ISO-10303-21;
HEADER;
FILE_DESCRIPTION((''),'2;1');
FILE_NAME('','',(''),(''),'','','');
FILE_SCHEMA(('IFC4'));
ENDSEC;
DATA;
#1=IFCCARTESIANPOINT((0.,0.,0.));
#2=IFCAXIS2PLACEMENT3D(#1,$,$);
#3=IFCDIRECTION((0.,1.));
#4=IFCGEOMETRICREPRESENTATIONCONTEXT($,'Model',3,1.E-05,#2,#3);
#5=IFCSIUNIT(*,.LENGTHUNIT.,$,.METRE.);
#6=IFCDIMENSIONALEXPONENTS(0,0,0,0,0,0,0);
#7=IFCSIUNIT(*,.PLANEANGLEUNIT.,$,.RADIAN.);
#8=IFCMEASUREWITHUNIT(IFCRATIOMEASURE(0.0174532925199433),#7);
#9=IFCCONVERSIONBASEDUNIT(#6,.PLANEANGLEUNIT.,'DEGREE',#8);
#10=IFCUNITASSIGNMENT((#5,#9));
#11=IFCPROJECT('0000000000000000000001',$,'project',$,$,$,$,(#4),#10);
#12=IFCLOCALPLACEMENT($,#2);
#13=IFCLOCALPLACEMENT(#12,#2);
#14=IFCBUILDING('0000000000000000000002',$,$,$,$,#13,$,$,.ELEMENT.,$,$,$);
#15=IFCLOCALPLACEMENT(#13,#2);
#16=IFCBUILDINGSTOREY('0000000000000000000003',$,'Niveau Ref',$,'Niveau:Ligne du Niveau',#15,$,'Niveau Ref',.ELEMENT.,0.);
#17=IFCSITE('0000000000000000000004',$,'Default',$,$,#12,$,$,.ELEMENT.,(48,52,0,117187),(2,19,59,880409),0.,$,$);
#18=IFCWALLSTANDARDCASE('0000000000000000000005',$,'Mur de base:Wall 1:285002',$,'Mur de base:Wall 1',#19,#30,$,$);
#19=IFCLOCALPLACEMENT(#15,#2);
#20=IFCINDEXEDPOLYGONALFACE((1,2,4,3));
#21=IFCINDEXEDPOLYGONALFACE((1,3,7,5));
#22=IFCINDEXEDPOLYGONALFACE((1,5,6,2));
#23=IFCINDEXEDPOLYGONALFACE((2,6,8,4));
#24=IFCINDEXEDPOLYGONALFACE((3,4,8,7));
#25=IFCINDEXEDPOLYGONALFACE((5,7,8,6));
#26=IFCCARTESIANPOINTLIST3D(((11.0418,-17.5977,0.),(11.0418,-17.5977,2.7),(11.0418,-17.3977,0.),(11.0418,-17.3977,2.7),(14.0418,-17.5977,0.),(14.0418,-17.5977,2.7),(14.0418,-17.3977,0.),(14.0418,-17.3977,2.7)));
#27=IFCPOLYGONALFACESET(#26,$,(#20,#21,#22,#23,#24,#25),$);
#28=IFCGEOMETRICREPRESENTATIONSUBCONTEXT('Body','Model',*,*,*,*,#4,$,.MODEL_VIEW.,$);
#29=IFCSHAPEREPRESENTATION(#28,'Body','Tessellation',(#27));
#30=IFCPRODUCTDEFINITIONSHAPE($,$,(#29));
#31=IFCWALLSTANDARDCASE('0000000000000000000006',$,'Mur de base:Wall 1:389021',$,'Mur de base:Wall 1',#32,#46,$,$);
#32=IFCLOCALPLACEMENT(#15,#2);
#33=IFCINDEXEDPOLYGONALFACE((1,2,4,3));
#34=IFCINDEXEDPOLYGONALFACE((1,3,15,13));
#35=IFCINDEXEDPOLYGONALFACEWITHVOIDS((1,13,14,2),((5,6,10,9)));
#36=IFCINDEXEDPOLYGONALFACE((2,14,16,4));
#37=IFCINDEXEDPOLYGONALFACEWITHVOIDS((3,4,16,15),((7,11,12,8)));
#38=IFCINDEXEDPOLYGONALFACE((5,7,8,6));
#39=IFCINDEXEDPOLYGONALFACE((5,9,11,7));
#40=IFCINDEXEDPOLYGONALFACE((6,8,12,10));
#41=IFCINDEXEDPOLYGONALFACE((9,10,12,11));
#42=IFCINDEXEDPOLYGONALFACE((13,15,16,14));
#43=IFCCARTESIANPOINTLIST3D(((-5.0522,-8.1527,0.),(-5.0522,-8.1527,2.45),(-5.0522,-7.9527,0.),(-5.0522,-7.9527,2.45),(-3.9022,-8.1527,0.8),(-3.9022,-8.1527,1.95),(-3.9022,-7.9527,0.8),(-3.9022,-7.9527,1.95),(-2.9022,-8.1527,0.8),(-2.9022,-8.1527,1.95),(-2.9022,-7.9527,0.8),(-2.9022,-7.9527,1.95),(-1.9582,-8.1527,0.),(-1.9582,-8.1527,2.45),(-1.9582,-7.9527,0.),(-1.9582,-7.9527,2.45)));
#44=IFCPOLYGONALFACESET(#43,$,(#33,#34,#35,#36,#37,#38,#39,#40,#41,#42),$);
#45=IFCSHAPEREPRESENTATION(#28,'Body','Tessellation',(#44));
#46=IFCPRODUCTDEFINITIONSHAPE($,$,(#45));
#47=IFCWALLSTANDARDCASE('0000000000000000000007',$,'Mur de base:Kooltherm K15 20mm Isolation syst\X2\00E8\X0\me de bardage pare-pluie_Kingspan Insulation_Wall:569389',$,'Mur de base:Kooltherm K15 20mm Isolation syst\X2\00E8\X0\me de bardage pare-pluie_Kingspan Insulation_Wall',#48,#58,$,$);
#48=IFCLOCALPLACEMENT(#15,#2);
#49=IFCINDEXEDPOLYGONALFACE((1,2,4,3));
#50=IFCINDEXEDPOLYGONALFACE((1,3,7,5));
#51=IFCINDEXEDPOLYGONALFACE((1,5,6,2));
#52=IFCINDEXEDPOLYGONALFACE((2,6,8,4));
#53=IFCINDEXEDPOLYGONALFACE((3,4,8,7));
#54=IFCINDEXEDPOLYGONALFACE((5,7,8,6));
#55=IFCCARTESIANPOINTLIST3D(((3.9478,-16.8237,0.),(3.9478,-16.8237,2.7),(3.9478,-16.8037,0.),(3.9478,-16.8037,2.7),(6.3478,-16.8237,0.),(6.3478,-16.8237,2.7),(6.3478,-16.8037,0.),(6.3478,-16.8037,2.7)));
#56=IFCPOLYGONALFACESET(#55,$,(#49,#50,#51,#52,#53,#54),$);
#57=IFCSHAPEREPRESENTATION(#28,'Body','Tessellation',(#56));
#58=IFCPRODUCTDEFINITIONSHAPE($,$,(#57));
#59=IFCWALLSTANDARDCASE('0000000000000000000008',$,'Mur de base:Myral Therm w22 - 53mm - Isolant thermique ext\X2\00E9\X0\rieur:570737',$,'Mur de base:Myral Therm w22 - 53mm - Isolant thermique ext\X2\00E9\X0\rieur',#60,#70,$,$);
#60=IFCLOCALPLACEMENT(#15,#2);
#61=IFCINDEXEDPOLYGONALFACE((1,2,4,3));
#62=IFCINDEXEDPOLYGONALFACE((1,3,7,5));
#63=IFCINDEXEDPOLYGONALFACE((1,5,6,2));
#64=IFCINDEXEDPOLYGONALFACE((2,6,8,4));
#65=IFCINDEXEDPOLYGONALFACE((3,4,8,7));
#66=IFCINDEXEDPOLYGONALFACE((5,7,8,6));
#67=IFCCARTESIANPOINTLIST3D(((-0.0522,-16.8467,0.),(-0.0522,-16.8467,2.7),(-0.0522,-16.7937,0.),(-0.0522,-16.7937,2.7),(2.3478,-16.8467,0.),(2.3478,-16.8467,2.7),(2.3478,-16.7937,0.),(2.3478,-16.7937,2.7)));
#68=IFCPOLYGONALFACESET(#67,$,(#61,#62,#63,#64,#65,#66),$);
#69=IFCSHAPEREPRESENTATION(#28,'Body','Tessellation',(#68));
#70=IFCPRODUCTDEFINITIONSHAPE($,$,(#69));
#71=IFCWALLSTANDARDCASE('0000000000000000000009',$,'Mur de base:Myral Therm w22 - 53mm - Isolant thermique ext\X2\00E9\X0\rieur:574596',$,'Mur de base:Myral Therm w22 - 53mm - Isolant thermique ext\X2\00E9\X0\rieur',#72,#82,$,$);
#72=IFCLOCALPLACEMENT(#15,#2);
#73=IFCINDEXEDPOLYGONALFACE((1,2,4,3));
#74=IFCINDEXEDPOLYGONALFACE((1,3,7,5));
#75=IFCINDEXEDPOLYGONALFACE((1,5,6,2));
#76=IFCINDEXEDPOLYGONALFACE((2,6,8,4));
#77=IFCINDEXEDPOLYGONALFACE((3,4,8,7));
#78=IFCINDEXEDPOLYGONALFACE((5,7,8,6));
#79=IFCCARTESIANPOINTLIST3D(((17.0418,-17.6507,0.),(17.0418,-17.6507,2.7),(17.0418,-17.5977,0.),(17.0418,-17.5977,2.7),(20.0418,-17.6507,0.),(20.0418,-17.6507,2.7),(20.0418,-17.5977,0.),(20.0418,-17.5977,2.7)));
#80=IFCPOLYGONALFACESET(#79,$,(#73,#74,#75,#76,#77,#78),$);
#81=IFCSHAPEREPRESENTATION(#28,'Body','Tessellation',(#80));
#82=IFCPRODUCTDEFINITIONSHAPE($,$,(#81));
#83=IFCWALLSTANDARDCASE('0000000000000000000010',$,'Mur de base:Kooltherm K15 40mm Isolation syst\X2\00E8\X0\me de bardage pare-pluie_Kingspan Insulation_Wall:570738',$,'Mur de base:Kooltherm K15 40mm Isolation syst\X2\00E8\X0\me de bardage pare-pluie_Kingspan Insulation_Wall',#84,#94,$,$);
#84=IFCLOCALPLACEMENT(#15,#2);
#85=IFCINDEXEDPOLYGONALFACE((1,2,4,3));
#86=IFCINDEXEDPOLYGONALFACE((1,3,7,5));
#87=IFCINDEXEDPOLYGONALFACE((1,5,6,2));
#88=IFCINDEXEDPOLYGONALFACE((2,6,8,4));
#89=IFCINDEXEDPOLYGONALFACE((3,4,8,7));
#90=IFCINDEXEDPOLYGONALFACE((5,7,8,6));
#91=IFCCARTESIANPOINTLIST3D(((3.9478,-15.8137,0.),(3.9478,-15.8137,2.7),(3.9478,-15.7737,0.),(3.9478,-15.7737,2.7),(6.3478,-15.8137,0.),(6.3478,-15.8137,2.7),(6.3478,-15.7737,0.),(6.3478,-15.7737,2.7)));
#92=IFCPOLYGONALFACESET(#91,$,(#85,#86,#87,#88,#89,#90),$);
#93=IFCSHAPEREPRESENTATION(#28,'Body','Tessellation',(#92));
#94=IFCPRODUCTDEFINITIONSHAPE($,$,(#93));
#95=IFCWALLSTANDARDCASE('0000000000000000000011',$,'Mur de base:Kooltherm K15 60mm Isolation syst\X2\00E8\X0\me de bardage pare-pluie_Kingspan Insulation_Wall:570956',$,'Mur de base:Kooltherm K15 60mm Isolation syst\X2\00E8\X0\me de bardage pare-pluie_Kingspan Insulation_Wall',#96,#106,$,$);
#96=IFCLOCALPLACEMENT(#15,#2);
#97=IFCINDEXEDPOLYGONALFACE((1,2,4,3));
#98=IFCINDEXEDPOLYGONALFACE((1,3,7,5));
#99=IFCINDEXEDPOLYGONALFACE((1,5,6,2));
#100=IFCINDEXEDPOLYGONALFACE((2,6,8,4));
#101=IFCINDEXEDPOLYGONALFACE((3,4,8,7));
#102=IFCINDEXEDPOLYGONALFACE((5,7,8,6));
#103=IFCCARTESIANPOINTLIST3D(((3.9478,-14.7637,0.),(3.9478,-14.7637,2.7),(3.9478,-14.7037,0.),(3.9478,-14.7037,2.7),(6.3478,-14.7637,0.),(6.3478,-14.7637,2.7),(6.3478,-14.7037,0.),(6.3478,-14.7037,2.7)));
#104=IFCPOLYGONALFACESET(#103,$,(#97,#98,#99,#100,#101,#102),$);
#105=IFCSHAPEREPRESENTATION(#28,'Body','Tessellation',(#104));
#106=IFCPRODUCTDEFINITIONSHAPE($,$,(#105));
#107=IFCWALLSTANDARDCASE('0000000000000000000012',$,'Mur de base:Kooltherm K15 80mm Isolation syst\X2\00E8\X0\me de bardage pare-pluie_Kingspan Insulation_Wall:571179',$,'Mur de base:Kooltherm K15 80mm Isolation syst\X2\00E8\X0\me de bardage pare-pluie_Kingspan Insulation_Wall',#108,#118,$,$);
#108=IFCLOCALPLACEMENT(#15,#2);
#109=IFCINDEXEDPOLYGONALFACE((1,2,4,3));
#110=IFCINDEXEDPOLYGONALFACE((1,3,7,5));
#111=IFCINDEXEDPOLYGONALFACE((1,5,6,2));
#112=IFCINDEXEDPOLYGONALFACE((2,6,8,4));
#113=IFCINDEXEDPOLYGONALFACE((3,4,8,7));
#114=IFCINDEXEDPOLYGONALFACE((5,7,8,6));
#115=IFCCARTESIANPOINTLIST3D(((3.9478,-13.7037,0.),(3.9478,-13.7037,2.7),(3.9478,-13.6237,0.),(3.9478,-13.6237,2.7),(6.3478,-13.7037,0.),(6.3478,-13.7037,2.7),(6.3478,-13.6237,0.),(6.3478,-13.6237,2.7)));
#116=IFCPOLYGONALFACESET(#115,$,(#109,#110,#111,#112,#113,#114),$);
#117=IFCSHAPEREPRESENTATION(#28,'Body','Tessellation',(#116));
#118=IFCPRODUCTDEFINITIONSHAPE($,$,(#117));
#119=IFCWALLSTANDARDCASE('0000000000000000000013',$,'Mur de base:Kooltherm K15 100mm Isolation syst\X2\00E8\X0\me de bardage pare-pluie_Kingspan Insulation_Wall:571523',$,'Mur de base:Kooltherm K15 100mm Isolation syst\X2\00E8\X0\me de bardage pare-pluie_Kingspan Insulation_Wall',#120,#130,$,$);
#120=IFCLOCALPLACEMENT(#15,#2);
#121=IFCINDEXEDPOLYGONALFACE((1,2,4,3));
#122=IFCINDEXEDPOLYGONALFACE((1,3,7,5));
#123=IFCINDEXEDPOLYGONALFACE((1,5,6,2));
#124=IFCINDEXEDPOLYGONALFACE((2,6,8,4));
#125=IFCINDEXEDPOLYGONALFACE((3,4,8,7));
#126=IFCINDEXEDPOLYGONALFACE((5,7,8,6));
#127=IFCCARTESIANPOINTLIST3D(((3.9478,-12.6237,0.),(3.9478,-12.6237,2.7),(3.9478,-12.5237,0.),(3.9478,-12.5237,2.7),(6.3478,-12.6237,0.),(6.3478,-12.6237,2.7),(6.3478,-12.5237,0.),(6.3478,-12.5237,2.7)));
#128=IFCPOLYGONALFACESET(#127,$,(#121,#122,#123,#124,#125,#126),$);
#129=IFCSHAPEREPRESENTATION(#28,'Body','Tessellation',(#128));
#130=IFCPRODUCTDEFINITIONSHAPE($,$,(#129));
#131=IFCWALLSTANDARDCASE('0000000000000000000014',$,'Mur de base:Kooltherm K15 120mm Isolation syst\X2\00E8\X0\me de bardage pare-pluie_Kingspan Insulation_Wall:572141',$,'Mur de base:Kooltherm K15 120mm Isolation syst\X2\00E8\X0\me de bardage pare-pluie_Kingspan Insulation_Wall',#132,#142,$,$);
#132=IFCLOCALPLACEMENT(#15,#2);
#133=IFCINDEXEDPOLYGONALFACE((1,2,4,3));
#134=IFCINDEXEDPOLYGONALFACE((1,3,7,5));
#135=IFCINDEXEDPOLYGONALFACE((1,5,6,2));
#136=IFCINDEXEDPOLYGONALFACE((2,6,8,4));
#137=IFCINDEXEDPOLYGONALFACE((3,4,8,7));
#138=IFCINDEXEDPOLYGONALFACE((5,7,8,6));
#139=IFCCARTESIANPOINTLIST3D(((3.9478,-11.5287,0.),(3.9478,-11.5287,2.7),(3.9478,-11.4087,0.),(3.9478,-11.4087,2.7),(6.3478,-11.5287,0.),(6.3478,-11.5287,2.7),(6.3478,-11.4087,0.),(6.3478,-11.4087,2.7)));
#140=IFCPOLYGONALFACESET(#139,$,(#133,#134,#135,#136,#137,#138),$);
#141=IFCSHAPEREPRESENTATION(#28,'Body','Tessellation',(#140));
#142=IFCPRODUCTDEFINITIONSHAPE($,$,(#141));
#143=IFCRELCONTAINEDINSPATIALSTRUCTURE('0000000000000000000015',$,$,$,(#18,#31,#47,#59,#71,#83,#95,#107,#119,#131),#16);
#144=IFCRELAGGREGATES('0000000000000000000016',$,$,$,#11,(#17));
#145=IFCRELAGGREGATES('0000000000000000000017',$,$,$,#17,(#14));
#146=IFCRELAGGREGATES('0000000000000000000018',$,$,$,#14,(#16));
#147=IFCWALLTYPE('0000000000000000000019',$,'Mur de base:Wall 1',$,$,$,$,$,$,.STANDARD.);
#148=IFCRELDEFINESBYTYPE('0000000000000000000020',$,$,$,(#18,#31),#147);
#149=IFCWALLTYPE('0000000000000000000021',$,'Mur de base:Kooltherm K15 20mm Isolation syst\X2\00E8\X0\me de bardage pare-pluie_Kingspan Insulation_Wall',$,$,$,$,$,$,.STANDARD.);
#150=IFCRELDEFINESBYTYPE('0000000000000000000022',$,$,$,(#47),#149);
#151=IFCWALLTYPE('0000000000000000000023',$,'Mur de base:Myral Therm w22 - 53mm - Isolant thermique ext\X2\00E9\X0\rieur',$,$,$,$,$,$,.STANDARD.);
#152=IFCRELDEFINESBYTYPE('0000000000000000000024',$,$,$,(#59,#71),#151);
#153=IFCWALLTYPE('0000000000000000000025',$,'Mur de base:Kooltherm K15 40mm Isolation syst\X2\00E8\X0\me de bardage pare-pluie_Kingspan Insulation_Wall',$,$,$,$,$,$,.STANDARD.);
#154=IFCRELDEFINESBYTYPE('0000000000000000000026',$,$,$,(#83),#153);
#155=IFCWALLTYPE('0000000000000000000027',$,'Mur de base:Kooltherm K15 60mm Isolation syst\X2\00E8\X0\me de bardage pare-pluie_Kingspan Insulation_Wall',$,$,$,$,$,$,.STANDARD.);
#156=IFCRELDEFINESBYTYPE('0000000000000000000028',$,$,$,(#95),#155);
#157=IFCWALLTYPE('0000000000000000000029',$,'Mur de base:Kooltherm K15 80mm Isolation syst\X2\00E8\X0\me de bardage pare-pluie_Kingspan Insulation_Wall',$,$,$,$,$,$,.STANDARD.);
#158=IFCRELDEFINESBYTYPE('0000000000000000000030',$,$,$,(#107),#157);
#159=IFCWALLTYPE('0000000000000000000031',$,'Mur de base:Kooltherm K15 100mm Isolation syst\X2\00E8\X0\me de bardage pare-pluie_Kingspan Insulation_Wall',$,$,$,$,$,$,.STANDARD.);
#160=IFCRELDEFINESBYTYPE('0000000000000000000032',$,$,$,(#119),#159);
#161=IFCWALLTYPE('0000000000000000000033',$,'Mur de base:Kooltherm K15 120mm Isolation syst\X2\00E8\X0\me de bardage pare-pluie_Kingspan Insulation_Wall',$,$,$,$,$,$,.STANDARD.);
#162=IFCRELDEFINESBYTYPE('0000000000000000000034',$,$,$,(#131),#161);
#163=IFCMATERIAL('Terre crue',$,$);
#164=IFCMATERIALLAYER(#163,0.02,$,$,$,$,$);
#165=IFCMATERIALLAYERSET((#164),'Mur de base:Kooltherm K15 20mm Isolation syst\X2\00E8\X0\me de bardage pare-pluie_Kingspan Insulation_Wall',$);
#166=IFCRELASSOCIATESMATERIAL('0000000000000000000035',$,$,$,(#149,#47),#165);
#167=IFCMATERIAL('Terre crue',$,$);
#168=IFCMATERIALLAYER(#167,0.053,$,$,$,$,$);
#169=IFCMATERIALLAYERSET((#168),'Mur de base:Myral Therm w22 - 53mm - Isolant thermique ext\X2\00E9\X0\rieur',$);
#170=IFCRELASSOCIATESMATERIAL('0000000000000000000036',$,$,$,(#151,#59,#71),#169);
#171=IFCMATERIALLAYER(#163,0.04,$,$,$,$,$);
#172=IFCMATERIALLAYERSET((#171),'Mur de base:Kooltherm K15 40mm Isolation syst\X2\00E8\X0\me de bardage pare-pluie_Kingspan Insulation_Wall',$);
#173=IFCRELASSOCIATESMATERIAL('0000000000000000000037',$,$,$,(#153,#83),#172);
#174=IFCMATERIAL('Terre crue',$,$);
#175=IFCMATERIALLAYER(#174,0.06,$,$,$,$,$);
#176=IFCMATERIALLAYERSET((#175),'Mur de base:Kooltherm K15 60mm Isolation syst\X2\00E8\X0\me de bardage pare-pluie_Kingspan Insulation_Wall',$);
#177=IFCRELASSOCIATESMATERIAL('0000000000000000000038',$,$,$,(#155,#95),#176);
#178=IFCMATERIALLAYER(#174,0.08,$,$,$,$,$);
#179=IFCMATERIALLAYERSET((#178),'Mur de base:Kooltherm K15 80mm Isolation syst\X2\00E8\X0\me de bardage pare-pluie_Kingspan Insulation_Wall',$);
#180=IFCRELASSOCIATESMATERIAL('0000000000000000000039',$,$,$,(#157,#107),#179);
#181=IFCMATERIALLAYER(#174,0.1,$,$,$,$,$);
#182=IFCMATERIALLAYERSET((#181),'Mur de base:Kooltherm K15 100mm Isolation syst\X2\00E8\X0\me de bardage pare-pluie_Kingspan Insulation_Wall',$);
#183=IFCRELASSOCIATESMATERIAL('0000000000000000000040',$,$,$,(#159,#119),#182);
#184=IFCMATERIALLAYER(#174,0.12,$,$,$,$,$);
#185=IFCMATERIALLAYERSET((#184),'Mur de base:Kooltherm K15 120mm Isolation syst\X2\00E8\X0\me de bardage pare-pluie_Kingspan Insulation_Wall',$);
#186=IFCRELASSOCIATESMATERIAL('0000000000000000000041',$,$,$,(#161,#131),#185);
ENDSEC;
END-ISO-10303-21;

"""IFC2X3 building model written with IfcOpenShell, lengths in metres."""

from ifc_helpers import new_model, entity, si_unit, converted_unit, direction, frame, frame_2d, origin, place, context, subcontext, project, spatial, rectangle, extrude, material, layer, layer_set, layer_usage, type_object, element, save


model = new_model("IFC2X3")

# Units and contexts
model_context = context("Model", 3, precision=1e-05, world=origin(), true_north=direction((0.0, 1.0)))
body_context = subcontext(model_context, "Body", "Model", "MODEL_VIEW")
ifc_project = project(units=[si_unit("LENGTHUNIT", "METRE"), converted_unit("PLANEANGLEUNIT", "DEGREE", entity("IfcRatioMeasure", 0.0174532925199433), si_unit("PLANEANGLEUNIT", "RADIAN"), dimensions=[0, 0, 0, 0, 0, 0, 0])], contexts=[model_context])

# Site, building, storey
site_placement = place(None, origin())
site = spatial("IfcSite", under=ifc_project, at=site_placement, Name="Default", CompositionType="ELEMENT", RefLatitude=(48, 52, 0, 117187), RefLongitude=(2, 19, 59, 880409), RefElevation=0.0)
building_placement = place(site_placement, origin())
building = spatial("IfcBuilding", under=site, at=building_placement, CompositionType="ELEMENT")
storey_placement = place(building_placement, origin())
storey = spatial("IfcBuildingStorey", under=building, at=storey_placement, Name="Niveau Ref", ObjectType="Niveau:Ligne du Niveau", LongName="Niveau Ref", CompositionType="ELEMENT", Elevation=0.0)

# Wall
wall_type_1 = type_object("IfcWallType", Name="Mur de base:Wall 1", PredefinedType="STANDARD")
for number, where, name in (
    (1, (11.0418, -17.4977, 0.0), "Mur de base:Wall 1:285002"),
):
    element("IfcWallStandardCase", number, at=place(storey_placement, frame(where)), inside=storey, type_object=wall_type_1, Name=name, ObjectType="Mur de base:Wall 1", context=body_context, shape_type="SweptSolid", body=[
        extrude(rectangle(XDim=3.0, YDim=0.2, at=frame_2d((1.5, 0.0), x_axis=(-1.0, 0.0))), origin(), (0.0, 0.0, 1.0), 2.7),
    ])

# Wall, opening
wall_1_placement = place(storey_placement, frame((-1.9582, -8.0527, 0.0), z_axis=(0.0, 0.0, 1.0), x_axis=(-1.0, 0.0, 0.0)))
wall_1 = element("IfcWallStandardCase", 2, at=wall_1_placement, inside=storey, type_object=wall_type_1, Name="Mur de base:Wall 1:389021", ObjectType="Mur de base:Wall 1", context=body_context, shape_type="SweptSolid", body=[
    extrude(rectangle(XDim=3.094, YDim=0.2, at=frame_2d((1.547, 0.0), x_axis=(-1.0, 0.0))), origin(), (0.0, 0.0, 1.0), 2.45),
])
opening_placement = place(wall_1_placement, frame((0.944, -0.1, 0.8)))
element("IfcOpeningElement", 3, at=opening_placement, cuts=wall_1, ObjectType="Opening", context=body_context, shape_type="SweptSolid", body=[
    extrude(rectangle(XDim=1.15, YDim=1.0, at=frame_2d((0.575, 0.5), x_axis=(1.0, 0.0))), frame((0.0, 0.0, 0.0), z_axis=(0.0, 1.0, 0.0), x_axis=(0.0, 0.0, 1.0)), (0.0, 0.0, 1.0), 0.2),
])

# Walls
ifc_material_1 = material(Name="Terre crue")
ifc_layer_1 = layer(ifc_material_1, 0.02)
ifc_layer_set_1 = layer_set([ifc_layer_1], Name="Mur de base:Kooltherm K15 20mm Isolation système de bardage pare-pluie_Kingspan Insulation_Wall")
ifc_layer_usage_1 = layer_usage(ifc_layer_set_1, "AXIS2", "NEGATIVE", 0.01)
wall_type_2 = type_object("IfcWallType", Name="Mur de base:Kooltherm K15 20mm Isolation système de bardage pare-pluie_Kingspan Insulation_Wall", PredefinedType="STANDARD", material=ifc_layer_set_1)
wall_2_placement = place(storey_placement, frame((3.9478, -16.8137, 0.0)))
element("IfcWallStandardCase", 4, at=wall_2_placement, inside=storey, type_object=wall_type_2, material=ifc_layer_usage_1, Name="Mur de base:Kooltherm K15 20mm Isolation système de bardage pare-pluie_Kingspan Insulation_Wall:569389", ObjectType="Mur de base:Kooltherm K15 20mm Isolation système de bardage pare-pluie_Kingspan Insulation_Wall", context=body_context, shape_type="SweptSolid", body=[
    extrude(rectangle(XDim=2.4, YDim=0.02, at=frame_2d((1.2, 0.0), x_axis=(-1.0, 0.0))), origin(), (0.0, 0.0, 1.0), 2.7),
])
ifc_material_2 = material(Name="Terre crue")
ifc_layer_2 = layer(ifc_material_2, 0.053)
ifc_layer_set_2 = layer_set([ifc_layer_2], Name="Mur de base:Myral Therm w22 - 53mm - Isolant thermique extérieur")
ifc_layer_usage_2 = layer_usage(ifc_layer_set_2, "AXIS2", "NEGATIVE", 0.0265)
wall_type_3 = type_object("IfcWallType", Name="Mur de base:Myral Therm w22 - 53mm - Isolant thermique extérieur", PredefinedType="STANDARD", material=ifc_layer_set_2)
wall_3_placement = place(storey_placement, frame((-0.0522, -16.8202, 0.0)))
element("IfcWallStandardCase", 5, at=wall_3_placement, inside=storey, type_object=wall_type_3, material=ifc_layer_usage_2, Name="Mur de base:Myral Therm w22 - 53mm - Isolant thermique extérieur:570737", ObjectType="Mur de base:Myral Therm w22 - 53mm - Isolant thermique extérieur", context=body_context, shape_type="SweptSolid", body=[
    extrude(rectangle(XDim=2.4, YDim=0.053, at=frame_2d((1.2, 0.0), x_axis=(-1.0, 0.0))), origin(), (0.0, 0.0, 1.0), 2.7),
])
ifc_layer_usage_3 = layer_usage(ifc_layer_set_2, "AXIS2", "NEGATIVE", 0.0265)
wall_4_placement = place(storey_placement, frame((17.0418, -17.6242, 0.0)))
element("IfcWallStandardCase", 6, at=wall_4_placement, inside=storey, type_object=wall_type_3, material=ifc_layer_usage_3, Name="Mur de base:Myral Therm w22 - 53mm - Isolant thermique extérieur:574596", ObjectType="Mur de base:Myral Therm w22 - 53mm - Isolant thermique extérieur", context=body_context, shape_type="SweptSolid", body=[
    extrude(rectangle(XDim=3.0, YDim=0.053, at=frame_2d((1.5, 0.0), x_axis=(-1.0, 0.0))), origin(), (0.0, 0.0, 1.0), 2.7),
])
ifc_layer_3 = layer(ifc_material_1, 0.04)
ifc_layer_set_3 = layer_set([ifc_layer_3], Name="Mur de base:Kooltherm K15 40mm Isolation système de bardage pare-pluie_Kingspan Insulation_Wall")
ifc_layer_usage_4 = layer_usage(ifc_layer_set_3, "AXIS2", "NEGATIVE", 0.02)
wall_type_4 = type_object("IfcWallType", Name="Mur de base:Kooltherm K15 40mm Isolation système de bardage pare-pluie_Kingspan Insulation_Wall", PredefinedType="STANDARD", material=ifc_layer_set_3)
wall_5_placement = place(storey_placement, frame((3.9478, -15.7937, 0.0)))
element("IfcWallStandardCase", 7, at=wall_5_placement, inside=storey, type_object=wall_type_4, material=ifc_layer_usage_4, Name="Mur de base:Kooltherm K15 40mm Isolation système de bardage pare-pluie_Kingspan Insulation_Wall:570738", ObjectType="Mur de base:Kooltherm K15 40mm Isolation système de bardage pare-pluie_Kingspan Insulation_Wall", context=body_context, shape_type="SweptSolid", body=[
    extrude(rectangle(XDim=2.4, YDim=0.04, at=frame_2d((1.2, 0.0), x_axis=(-1.0, 0.0))), origin(), (0.0, 0.0, 1.0), 2.7),
])
ifc_material_3 = material(Name="Terre crue")
ifc_layer_4 = layer(ifc_material_3, 0.06)
ifc_layer_set_4 = layer_set([ifc_layer_4], Name="Mur de base:Kooltherm K15 60mm Isolation système de bardage pare-pluie_Kingspan Insulation_Wall")
ifc_layer_usage_5 = layer_usage(ifc_layer_set_4, "AXIS2", "NEGATIVE", 0.03)
wall_type_5 = type_object("IfcWallType", Name="Mur de base:Kooltherm K15 60mm Isolation système de bardage pare-pluie_Kingspan Insulation_Wall", PredefinedType="STANDARD", material=ifc_layer_set_4)
wall_6_placement = place(storey_placement, frame((3.9478, -14.7337, 0.0)))
element("IfcWallStandardCase", 8, at=wall_6_placement, inside=storey, type_object=wall_type_5, material=ifc_layer_usage_5, Name="Mur de base:Kooltherm K15 60mm Isolation système de bardage pare-pluie_Kingspan Insulation_Wall:570956", ObjectType="Mur de base:Kooltherm K15 60mm Isolation système de bardage pare-pluie_Kingspan Insulation_Wall", context=body_context, shape_type="SweptSolid", body=[
    extrude(rectangle(XDim=2.4, YDim=0.06, at=frame_2d((1.2, 0.0), x_axis=(-1.0, 0.0))), origin(), (0.0, 0.0, 1.0), 2.7),
])
ifc_layer_5 = layer(ifc_material_3, 0.08)
ifc_layer_set_5 = layer_set([ifc_layer_5], Name="Mur de base:Kooltherm K15 80mm Isolation système de bardage pare-pluie_Kingspan Insulation_Wall")
ifc_layer_usage_6 = layer_usage(ifc_layer_set_5, "AXIS2", "NEGATIVE", 0.04)
wall_type_6 = type_object("IfcWallType", Name="Mur de base:Kooltherm K15 80mm Isolation système de bardage pare-pluie_Kingspan Insulation_Wall", PredefinedType="STANDARD", material=ifc_layer_set_5)
wall_7_placement = place(storey_placement, frame((3.9478, -13.6637, 0.0)))
element("IfcWallStandardCase", 9, at=wall_7_placement, inside=storey, type_object=wall_type_6, material=ifc_layer_usage_6, Name="Mur de base:Kooltherm K15 80mm Isolation système de bardage pare-pluie_Kingspan Insulation_Wall:571179", ObjectType="Mur de base:Kooltherm K15 80mm Isolation système de bardage pare-pluie_Kingspan Insulation_Wall", context=body_context, shape_type="SweptSolid", body=[
    extrude(rectangle(XDim=2.4, YDim=0.08, at=frame_2d((1.2, 0.0), x_axis=(-1.0, 0.0))), origin(), (0.0, 0.0, 1.0), 2.7),
])
ifc_layer_6 = layer(ifc_material_3, 0.1)
ifc_layer_set_6 = layer_set([ifc_layer_6], Name="Mur de base:Kooltherm K15 100mm Isolation système de bardage pare-pluie_Kingspan Insulation_Wall")
ifc_layer_usage_7 = layer_usage(ifc_layer_set_6, "AXIS2", "NEGATIVE", 0.05)
wall_type_7 = type_object("IfcWallType", Name="Mur de base:Kooltherm K15 100mm Isolation système de bardage pare-pluie_Kingspan Insulation_Wall", PredefinedType="STANDARD", material=ifc_layer_set_6)
wall_8_placement = place(storey_placement, frame((3.9478, -12.5737, 0.0)))
element("IfcWallStandardCase", 10, at=wall_8_placement, inside=storey, type_object=wall_type_7, material=ifc_layer_usage_7, Name="Mur de base:Kooltherm K15 100mm Isolation système de bardage pare-pluie_Kingspan Insulation_Wall:571523", ObjectType="Mur de base:Kooltherm K15 100mm Isolation système de bardage pare-pluie_Kingspan Insulation_Wall", context=body_context, shape_type="SweptSolid", body=[
    extrude(rectangle(XDim=2.4, YDim=0.1, at=frame_2d((1.2, 0.0), x_axis=(-1.0, 0.0))), origin(), (0.0, 0.0, 1.0), 2.7),
])
ifc_layer_7 = layer(ifc_material_3, 0.12)
ifc_layer_set_7 = layer_set([ifc_layer_7], Name="Mur de base:Kooltherm K15 120mm Isolation système de bardage pare-pluie_Kingspan Insulation_Wall")
ifc_layer_usage_8 = layer_usage(ifc_layer_set_7, "AXIS2", "NEGATIVE", 0.06)
wall_type_8 = type_object("IfcWallType", Name="Mur de base:Kooltherm K15 120mm Isolation système de bardage pare-pluie_Kingspan Insulation_Wall", PredefinedType="STANDARD", material=ifc_layer_set_7)
wall_9_placement = place(storey_placement, frame((3.9478, -11.4687, 0.0)))
element("IfcWallStandardCase", 11, at=wall_9_placement, inside=storey, type_object=wall_type_8, material=ifc_layer_usage_8, Name="Mur de base:Kooltherm K15 120mm Isolation système de bardage pare-pluie_Kingspan Insulation_Wall:572141", ObjectType="Mur de base:Kooltherm K15 120mm Isolation système de bardage pare-pluie_Kingspan Insulation_Wall", context=body_context, shape_type="SweptSolid", body=[
    extrude(rectangle(XDim=2.4, YDim=0.12, at=frame_2d((1.2, 0.0), x_axis=(-1.0, 0.0))), origin(), (0.0, 0.0, 1.0), 2.7),
])

save(model, "model.ifc")
